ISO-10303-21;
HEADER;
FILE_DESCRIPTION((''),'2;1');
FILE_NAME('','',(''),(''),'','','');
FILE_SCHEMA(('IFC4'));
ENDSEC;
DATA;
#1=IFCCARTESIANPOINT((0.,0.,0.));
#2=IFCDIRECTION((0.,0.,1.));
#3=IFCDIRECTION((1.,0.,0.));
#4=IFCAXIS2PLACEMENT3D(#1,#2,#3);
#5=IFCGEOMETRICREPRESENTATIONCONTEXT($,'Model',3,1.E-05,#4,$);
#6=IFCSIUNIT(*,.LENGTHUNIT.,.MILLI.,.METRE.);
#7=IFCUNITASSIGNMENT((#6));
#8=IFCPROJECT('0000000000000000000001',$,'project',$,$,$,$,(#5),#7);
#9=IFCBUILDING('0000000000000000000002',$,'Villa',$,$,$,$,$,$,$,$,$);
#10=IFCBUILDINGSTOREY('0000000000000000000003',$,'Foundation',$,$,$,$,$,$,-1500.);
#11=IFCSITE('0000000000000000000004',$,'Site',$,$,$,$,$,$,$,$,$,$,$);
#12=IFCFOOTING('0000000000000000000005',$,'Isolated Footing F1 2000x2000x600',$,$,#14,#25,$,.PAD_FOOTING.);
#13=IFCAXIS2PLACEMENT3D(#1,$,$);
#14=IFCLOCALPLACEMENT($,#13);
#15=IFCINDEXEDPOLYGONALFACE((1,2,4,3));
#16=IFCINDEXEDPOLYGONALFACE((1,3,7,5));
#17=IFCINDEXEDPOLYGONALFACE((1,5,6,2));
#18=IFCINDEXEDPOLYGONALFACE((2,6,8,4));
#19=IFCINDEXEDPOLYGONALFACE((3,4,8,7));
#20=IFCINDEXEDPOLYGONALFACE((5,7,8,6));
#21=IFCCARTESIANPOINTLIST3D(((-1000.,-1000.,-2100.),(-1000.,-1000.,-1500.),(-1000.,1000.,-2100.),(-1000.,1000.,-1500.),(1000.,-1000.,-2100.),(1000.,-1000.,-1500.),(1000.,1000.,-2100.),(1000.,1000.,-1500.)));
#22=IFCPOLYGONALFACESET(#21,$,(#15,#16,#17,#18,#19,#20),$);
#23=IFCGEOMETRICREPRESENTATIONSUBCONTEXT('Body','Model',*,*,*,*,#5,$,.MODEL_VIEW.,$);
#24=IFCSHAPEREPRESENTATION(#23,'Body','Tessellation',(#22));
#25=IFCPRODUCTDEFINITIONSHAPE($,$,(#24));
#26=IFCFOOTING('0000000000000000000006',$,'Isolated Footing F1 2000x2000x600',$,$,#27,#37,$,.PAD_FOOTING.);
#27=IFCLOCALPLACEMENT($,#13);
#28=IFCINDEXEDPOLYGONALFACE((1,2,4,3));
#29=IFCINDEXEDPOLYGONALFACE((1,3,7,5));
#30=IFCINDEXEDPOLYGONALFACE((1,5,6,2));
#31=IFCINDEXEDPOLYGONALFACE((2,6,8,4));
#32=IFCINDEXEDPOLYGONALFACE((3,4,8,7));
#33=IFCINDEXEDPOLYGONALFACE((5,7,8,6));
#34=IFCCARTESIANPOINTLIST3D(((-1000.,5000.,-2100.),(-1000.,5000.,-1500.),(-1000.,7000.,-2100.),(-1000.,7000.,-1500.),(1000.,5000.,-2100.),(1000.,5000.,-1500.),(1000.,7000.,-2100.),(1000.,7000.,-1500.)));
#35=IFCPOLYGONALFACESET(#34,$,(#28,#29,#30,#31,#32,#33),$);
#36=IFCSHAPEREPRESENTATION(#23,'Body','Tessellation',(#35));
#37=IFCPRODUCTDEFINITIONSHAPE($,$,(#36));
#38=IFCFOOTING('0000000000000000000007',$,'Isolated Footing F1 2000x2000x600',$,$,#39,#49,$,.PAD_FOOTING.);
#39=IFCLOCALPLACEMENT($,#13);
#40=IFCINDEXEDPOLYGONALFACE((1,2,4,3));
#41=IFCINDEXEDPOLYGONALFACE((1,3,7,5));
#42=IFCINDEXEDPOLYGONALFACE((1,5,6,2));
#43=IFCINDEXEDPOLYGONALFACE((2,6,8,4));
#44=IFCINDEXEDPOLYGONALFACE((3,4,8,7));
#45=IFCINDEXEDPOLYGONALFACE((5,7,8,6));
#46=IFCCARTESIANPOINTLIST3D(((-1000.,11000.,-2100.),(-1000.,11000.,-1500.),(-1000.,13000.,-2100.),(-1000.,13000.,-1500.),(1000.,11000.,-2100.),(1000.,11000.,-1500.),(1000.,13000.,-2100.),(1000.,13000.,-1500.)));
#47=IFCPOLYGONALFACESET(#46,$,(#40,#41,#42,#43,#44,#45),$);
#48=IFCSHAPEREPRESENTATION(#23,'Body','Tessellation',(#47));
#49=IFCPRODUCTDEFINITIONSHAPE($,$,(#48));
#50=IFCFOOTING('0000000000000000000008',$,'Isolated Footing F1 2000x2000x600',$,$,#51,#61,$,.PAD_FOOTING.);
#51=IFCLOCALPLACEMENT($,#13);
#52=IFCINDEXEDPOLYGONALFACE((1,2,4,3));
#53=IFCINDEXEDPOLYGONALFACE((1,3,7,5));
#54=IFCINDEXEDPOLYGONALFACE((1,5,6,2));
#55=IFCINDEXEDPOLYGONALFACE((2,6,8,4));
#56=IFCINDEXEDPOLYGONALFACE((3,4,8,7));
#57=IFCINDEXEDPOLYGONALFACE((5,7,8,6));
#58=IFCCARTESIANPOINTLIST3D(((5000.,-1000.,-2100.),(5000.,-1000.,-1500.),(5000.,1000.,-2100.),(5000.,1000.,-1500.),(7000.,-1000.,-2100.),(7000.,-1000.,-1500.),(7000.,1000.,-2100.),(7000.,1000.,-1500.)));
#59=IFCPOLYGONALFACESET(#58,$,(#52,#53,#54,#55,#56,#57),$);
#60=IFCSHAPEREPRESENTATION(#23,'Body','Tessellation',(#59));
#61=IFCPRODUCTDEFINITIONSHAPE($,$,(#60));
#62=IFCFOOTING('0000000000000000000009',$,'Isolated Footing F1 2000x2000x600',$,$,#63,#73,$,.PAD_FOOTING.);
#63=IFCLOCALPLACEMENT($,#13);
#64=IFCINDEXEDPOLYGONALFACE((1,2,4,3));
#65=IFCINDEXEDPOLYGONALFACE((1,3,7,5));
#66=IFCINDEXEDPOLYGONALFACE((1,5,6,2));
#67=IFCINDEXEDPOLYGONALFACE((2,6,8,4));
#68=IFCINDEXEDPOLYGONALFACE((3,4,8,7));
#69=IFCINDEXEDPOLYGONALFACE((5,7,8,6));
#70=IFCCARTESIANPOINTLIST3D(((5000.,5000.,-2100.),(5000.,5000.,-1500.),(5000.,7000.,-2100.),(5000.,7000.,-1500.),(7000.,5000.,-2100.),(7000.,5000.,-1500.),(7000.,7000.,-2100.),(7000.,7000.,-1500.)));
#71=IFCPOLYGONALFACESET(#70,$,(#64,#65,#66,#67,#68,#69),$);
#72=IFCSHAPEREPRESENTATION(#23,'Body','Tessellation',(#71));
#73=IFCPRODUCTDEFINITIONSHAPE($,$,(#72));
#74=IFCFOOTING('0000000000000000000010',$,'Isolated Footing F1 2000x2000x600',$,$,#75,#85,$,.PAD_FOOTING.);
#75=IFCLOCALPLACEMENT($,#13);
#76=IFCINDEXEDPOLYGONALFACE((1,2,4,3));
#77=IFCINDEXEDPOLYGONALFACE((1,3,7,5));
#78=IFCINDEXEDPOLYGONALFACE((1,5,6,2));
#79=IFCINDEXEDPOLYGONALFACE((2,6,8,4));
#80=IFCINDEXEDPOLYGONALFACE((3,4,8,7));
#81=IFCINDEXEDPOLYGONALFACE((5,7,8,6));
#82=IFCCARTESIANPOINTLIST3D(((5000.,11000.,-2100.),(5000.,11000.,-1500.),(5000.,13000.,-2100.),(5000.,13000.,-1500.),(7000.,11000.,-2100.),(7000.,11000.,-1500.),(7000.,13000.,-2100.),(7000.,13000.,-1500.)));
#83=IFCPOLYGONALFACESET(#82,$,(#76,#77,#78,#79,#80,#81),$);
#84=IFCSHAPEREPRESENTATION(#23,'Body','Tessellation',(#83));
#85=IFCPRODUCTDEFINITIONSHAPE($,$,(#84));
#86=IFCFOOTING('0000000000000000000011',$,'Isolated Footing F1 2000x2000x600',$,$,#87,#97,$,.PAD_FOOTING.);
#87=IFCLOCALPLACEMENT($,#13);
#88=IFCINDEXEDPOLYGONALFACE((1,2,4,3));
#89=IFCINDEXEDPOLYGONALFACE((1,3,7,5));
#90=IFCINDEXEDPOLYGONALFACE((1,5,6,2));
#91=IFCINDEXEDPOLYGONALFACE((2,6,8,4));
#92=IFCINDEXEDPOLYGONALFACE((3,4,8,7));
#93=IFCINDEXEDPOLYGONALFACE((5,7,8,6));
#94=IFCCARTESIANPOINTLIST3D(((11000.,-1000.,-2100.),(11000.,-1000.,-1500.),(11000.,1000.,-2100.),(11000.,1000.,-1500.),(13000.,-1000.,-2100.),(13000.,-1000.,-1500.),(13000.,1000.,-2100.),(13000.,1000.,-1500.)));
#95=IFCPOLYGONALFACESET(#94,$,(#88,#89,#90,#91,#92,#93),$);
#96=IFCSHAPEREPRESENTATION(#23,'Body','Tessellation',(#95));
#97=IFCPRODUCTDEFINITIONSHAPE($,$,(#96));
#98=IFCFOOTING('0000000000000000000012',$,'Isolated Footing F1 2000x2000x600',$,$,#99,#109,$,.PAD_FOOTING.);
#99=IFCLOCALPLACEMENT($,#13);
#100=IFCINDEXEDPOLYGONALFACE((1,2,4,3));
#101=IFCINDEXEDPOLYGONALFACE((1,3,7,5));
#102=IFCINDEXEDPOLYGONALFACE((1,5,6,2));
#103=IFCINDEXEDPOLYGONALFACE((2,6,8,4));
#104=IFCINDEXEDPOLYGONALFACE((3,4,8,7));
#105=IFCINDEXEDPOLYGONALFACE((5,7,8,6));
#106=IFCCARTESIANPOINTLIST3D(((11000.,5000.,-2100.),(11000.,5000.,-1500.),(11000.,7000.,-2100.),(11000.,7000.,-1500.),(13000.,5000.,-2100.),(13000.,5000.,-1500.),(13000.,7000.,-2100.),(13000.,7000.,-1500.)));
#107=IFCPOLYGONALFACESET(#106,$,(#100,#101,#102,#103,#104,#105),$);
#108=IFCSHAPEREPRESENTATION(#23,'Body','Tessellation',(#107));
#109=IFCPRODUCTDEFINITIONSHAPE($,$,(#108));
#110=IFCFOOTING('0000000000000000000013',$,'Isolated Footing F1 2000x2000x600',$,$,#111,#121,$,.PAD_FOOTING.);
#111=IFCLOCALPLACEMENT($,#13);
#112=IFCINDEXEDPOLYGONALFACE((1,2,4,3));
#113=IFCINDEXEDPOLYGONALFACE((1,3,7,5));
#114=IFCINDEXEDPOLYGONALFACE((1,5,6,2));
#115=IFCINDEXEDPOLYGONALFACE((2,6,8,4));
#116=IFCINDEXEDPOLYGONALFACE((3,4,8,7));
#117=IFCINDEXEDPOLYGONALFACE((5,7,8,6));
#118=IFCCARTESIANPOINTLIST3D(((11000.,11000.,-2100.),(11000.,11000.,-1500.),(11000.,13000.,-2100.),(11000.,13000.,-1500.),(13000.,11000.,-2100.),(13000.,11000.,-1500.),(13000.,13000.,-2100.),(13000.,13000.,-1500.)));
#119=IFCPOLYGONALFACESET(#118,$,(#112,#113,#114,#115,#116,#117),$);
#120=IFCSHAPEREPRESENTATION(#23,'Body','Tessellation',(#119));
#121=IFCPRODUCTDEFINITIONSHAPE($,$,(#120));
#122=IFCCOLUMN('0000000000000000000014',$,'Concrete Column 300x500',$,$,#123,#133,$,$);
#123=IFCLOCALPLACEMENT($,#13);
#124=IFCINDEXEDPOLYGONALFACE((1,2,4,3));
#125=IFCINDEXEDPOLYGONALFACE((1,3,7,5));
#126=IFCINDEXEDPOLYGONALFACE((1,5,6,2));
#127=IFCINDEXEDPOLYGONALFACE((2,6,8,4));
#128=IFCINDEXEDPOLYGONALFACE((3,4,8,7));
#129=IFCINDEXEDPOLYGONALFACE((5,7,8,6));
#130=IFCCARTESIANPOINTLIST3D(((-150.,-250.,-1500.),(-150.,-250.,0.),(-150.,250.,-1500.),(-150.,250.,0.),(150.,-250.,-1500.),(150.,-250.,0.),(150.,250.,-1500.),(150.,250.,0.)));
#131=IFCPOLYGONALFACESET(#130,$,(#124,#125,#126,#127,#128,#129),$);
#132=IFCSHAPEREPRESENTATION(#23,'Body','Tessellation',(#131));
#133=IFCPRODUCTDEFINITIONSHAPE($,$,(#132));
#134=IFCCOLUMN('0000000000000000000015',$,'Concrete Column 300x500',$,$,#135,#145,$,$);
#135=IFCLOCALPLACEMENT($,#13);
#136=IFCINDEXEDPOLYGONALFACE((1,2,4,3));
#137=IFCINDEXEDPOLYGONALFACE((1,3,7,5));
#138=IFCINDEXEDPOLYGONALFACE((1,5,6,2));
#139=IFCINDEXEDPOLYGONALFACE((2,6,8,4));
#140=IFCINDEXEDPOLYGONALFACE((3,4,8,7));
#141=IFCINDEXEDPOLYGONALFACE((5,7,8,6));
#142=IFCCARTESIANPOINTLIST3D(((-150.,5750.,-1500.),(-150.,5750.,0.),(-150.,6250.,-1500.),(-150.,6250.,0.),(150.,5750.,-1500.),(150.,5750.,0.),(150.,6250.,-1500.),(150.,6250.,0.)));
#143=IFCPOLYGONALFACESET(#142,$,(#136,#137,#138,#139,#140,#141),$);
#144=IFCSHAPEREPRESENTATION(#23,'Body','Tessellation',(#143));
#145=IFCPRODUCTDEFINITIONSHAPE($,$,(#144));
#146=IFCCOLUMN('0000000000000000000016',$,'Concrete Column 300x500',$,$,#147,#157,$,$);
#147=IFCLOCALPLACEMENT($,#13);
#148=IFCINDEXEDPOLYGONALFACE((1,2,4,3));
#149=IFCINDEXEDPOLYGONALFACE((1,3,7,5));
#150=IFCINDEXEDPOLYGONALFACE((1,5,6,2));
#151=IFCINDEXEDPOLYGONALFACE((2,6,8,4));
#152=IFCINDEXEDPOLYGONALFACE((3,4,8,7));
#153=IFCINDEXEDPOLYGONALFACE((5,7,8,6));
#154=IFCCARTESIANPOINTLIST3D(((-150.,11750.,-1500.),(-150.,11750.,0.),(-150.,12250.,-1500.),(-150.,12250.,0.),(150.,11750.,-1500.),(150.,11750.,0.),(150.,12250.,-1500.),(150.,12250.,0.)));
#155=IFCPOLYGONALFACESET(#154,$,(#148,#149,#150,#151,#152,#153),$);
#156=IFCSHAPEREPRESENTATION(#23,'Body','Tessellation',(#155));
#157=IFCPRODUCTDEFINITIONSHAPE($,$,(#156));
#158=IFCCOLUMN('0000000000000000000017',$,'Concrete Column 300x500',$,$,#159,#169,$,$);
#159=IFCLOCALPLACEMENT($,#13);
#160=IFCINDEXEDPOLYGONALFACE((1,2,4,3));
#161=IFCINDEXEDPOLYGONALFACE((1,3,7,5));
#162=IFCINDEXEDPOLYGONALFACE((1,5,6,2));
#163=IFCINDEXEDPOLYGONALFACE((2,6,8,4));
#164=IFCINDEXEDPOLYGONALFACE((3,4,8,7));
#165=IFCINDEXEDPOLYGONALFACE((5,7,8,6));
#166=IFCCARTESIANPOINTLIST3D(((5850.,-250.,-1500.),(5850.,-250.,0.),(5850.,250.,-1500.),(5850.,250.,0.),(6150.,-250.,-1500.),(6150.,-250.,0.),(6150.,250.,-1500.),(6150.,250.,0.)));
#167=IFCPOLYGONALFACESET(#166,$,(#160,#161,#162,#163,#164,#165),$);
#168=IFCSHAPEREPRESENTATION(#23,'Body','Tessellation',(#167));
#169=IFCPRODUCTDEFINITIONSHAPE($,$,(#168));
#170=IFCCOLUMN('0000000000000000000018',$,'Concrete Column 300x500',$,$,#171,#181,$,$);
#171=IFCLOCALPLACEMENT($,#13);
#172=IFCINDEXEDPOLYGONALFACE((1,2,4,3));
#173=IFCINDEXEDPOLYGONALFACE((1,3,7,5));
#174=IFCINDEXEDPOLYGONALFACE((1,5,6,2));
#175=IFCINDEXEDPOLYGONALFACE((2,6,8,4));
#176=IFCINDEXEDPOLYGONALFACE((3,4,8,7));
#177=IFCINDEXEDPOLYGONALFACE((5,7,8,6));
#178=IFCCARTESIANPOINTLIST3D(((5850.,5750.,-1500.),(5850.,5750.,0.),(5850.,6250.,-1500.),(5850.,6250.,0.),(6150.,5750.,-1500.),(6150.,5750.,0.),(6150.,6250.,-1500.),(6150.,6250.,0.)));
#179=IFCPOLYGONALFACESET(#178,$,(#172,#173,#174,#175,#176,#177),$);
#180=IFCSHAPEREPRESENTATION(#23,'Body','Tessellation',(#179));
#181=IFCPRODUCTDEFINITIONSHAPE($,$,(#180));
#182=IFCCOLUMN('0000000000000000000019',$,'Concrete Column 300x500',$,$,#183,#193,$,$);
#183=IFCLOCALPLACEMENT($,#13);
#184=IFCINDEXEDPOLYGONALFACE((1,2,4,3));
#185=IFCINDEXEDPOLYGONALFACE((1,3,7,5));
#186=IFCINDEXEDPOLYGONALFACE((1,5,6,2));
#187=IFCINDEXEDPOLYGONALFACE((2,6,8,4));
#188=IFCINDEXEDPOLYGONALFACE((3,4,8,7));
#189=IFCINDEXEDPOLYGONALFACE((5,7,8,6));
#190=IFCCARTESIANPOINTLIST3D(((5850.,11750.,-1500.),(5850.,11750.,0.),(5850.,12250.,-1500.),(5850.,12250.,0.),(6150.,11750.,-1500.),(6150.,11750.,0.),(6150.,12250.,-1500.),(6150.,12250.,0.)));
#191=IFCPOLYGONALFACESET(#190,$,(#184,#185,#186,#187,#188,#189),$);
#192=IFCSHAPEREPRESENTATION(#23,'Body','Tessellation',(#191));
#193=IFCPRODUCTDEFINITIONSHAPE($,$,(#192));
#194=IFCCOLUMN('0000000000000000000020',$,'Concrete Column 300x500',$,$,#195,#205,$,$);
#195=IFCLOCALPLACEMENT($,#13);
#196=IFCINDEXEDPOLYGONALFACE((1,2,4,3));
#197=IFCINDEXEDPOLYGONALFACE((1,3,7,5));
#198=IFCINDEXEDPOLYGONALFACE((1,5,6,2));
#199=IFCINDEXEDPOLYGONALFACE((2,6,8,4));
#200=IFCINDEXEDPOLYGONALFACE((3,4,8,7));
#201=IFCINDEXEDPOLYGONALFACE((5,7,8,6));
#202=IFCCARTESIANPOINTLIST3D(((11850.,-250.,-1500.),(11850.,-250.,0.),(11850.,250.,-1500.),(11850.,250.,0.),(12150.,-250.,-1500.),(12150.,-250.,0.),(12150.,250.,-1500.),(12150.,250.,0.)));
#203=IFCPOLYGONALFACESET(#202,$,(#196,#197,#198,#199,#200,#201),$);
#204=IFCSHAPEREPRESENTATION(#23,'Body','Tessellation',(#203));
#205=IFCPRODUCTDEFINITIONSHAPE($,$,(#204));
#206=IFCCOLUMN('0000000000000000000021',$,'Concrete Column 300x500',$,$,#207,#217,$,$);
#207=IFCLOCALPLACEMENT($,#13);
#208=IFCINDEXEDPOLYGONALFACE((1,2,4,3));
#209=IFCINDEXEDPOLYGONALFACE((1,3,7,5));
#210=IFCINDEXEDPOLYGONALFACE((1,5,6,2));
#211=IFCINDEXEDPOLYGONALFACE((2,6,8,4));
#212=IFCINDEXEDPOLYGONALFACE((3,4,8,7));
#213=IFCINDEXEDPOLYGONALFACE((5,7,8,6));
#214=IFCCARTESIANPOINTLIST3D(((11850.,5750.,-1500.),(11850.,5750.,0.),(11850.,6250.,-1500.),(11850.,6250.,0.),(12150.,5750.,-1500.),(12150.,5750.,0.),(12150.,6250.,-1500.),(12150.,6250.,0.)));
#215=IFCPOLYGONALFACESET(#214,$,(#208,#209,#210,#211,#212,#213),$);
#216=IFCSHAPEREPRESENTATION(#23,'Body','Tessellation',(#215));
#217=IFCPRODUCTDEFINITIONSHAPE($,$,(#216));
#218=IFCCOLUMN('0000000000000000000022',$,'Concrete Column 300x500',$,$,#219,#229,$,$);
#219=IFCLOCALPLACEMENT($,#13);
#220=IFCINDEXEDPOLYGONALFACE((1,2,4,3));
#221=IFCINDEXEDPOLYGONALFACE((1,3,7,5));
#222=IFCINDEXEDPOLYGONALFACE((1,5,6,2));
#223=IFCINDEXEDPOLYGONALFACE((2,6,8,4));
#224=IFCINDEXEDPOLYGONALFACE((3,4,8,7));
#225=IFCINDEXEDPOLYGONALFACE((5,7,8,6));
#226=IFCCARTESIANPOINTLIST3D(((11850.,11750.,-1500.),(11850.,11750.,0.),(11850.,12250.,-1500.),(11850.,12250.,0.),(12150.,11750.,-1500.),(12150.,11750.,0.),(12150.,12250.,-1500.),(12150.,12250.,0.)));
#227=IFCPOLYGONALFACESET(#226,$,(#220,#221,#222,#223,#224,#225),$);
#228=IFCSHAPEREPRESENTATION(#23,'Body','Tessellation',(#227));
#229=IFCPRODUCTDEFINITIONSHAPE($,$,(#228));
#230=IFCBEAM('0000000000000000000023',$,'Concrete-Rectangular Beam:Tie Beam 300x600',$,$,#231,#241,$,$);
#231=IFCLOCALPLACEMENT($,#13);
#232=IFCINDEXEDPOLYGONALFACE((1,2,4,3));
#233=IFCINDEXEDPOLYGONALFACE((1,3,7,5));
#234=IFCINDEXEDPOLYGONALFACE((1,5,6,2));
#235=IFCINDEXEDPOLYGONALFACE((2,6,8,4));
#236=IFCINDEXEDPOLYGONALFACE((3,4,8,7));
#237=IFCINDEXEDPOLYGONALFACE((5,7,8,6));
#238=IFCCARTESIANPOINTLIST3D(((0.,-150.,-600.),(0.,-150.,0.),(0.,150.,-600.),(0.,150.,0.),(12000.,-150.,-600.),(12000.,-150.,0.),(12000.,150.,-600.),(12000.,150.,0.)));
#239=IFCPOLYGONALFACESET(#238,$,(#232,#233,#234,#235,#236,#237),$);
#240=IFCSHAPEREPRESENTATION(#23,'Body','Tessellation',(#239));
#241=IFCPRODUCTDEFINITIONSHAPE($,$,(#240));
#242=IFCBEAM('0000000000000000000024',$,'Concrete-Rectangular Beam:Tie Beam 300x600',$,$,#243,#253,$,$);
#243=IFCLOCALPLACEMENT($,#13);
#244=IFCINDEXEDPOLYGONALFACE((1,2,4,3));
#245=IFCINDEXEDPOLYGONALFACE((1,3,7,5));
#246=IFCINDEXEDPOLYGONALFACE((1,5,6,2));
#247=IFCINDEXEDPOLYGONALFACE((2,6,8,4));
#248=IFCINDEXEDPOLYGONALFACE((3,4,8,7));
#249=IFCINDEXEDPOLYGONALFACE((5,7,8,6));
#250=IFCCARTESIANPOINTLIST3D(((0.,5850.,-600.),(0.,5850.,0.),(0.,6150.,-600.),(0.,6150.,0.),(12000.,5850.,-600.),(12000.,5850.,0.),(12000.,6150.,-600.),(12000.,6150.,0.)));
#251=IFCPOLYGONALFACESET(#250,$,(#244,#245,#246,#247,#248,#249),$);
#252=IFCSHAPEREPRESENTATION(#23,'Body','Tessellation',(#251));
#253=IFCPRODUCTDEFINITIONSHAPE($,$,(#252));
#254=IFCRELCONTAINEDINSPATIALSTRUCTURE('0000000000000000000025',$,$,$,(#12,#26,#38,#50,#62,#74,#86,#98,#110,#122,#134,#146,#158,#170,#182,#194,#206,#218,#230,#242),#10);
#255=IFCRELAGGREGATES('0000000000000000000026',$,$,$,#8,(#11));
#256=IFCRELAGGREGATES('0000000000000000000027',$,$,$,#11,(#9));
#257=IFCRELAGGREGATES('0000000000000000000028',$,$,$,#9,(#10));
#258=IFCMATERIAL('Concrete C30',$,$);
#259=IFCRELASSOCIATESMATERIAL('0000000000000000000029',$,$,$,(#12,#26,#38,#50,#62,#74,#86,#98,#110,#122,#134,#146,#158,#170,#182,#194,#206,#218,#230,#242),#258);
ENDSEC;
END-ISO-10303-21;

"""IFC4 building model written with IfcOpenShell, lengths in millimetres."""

from ifc_helpers import new_model, si_unit, frame, origin_with_axes, place, context, subcontext, project, spatial, indexed_curve, outline, extrude, material, element, save


model = new_model("IFC4")

# Units and contexts
model_context = context("Model", 3, precision=1e-05, world=origin_with_axes())
body_context = subcontext(model_context, "Body", "Model", "MODEL_VIEW")
ifc_project = project(units=[si_unit("LENGTHUNIT", "METRE", prefix="MILLI")], contexts=[model_context])

# Site, building, storey
site = spatial("IfcSite", under=ifc_project, Name="Site")
building = spatial("IfcBuilding", under=site, Name="Villa")
storey = spatial("IfcBuildingStorey", under=building, Name="Foundation", Elevation=-1500.0)

# Footings
ifc_material = material(Name="Concrete C30")
for number, where, z_axis, x_axis, name in (
    (1, (-1000.0, -1000.0, -2100.0), (0.0, 0.0, 1.0), (1.0, 0.0, 0.0), "Isolated Footing F1 2000x2000x600"),
    (2, (-1000.0, 5000.0, -2100.0), (0.0, 0.0, 1.0), (1.0, 0.0, 0.0), "Isolated Footing F1 2000x2000x600"),
    (3, (-1000.0, 11000.0, -2100.0), (0.0, 0.0, 1.0), (1.0, 0.0, 0.0), "Isolated Footing F1 2000x2000x600"),
    (4, (5000.0, -1000.0, -2100.0), (0.0, 0.0, 1.0), (1.0, 0.0, 0.0), "Isolated Footing F1 2000x2000x600"),
    (5, (5000.0, 5000.0, -2100.0), (0.0, 0.0, 1.0), (1.0, 0.0, 0.0), "Isolated Footing F1 2000x2000x600"),
    (6, (5000.0, 11000.0, -2100.0), (0.0, 0.0, 1.0), (1.0, 0.0, 0.0), "Isolated Footing F1 2000x2000x600"),
    (7, (11000.0, -1000.0, -2100.0), (0.0, 0.0, 1.0), (1.0, 0.0, 0.0), "Isolated Footing F1 2000x2000x600"),
    (8, (11000.0, 5000.0, -2100.0), (0.0, 0.0, 1.0), (1.0, 0.0, 0.0), "Isolated Footing F1 2000x2000x600"),
    (9, (11000.0, 11000.0, -2100.0), (0.0, 0.0, 1.0), (1.0, 0.0, 0.0), "Isolated Footing F1 2000x2000x600"),
):
    element("IfcFooting", number, at=place(None, frame(where, z_axis=z_axis, x_axis=x_axis)), inside=storey, material=ifc_material, Name=name, PredefinedType="PAD_FOOTING", context=body_context, shape_type="SweptSolid", body=[
        extrude(outline(indexed_curve([(0.0, 0.0), (0.0, 2000.0), (2000.0, 2000.0), (2000.0, 0.0), (0.0, 0.0)], self_intersect=False)), origin_with_axes(), (0.0, 0.0, 1.0), 600.0),
    ])

# Columns
for number, where, z_axis, x_axis, name in (
    (10, (-150.0, -250.0, -1500.0), (0.0, 0.0, 1.0), (1.0, 0.0, 0.0), "Concrete Column 300x500"),
    (11, (-150.0, 5750.0, -1500.0), (0.0, 0.0, 1.0), (1.0, 0.0, 0.0), "Concrete Column 300x500"),
    (12, (-150.0, 11750.0, -1500.0), (0.0, 0.0, 1.0), (1.0, 0.0, 0.0), "Concrete Column 300x500"),
    (13, (5850.0, -250.0, -1500.0), (0.0, 0.0, 1.0), (1.0, 0.0, 0.0), "Concrete Column 300x500"),
    (14, (5850.0, 5750.0, -1500.0), (0.0, 0.0, 1.0), (1.0, 0.0, 0.0), "Concrete Column 300x500"),
    (15, (5850.0, 11750.0, -1500.0), (0.0, 0.0, 1.0), (1.0, 0.0, 0.0), "Concrete Column 300x500"),
    (16, (11850.0, -250.0, -1500.0), (0.0, 0.0, 1.0), (1.0, 0.0, 0.0), "Concrete Column 300x500"),
    (17, (11850.0, 5750.0, -1500.0), (0.0, 0.0, 1.0), (1.0, 0.0, 0.0), "Concrete Column 300x500"),
    (18, (11850.0, 11750.0, -1500.0), (0.0, 0.0, 1.0), (1.0, 0.0, 0.0), "Concrete Column 300x500"),
):
    element("IfcColumn", number, at=place(None, frame(where, z_axis=z_axis, x_axis=x_axis)), inside=storey, material=ifc_material, Name=name, context=body_context, shape_type="SweptSolid", body=[
        extrude(outline(indexed_curve([(0.0, 0.0), (0.0, 500.0), (300.0, 500.0), (300.0, 0.0), (0.0, 0.0)], self_intersect=False)), origin_with_axes(), (0.0, 0.0, 1.0), 1500.0),
    ])

# Beams
for number, where, z_axis, x_axis, name in (
    (19, (0.0, -150.0, -600.0), (0.0, 0.0, 1.0), (1.0, 0.0, 0.0), "Concrete-Rectangular Beam:Tie Beam 300x600"),
    (20, (0.0, 5850.0, -600.0), (0.0, 0.0, 1.0), (1.0, 0.0, 0.0), "Concrete-Rectangular Beam:Tie Beam 300x600"),
):
    element("IfcBeam", number, at=place(None, frame(where, z_axis=z_axis, x_axis=x_axis)), inside=storey, material=ifc_material, Name=name, context=body_context, shape_type="SweptSolid", body=[
        extrude(outline(indexed_curve([(0.0, 0.0), (0.0, 300.0), (12000.0, 300.0), (12000.0, 0.0), (0.0, 0.0)], self_intersect=False)), origin_with_axes(), (0.0, 0.0, 1.0), 600.0),
    ])

save(model, "model.ifc")
